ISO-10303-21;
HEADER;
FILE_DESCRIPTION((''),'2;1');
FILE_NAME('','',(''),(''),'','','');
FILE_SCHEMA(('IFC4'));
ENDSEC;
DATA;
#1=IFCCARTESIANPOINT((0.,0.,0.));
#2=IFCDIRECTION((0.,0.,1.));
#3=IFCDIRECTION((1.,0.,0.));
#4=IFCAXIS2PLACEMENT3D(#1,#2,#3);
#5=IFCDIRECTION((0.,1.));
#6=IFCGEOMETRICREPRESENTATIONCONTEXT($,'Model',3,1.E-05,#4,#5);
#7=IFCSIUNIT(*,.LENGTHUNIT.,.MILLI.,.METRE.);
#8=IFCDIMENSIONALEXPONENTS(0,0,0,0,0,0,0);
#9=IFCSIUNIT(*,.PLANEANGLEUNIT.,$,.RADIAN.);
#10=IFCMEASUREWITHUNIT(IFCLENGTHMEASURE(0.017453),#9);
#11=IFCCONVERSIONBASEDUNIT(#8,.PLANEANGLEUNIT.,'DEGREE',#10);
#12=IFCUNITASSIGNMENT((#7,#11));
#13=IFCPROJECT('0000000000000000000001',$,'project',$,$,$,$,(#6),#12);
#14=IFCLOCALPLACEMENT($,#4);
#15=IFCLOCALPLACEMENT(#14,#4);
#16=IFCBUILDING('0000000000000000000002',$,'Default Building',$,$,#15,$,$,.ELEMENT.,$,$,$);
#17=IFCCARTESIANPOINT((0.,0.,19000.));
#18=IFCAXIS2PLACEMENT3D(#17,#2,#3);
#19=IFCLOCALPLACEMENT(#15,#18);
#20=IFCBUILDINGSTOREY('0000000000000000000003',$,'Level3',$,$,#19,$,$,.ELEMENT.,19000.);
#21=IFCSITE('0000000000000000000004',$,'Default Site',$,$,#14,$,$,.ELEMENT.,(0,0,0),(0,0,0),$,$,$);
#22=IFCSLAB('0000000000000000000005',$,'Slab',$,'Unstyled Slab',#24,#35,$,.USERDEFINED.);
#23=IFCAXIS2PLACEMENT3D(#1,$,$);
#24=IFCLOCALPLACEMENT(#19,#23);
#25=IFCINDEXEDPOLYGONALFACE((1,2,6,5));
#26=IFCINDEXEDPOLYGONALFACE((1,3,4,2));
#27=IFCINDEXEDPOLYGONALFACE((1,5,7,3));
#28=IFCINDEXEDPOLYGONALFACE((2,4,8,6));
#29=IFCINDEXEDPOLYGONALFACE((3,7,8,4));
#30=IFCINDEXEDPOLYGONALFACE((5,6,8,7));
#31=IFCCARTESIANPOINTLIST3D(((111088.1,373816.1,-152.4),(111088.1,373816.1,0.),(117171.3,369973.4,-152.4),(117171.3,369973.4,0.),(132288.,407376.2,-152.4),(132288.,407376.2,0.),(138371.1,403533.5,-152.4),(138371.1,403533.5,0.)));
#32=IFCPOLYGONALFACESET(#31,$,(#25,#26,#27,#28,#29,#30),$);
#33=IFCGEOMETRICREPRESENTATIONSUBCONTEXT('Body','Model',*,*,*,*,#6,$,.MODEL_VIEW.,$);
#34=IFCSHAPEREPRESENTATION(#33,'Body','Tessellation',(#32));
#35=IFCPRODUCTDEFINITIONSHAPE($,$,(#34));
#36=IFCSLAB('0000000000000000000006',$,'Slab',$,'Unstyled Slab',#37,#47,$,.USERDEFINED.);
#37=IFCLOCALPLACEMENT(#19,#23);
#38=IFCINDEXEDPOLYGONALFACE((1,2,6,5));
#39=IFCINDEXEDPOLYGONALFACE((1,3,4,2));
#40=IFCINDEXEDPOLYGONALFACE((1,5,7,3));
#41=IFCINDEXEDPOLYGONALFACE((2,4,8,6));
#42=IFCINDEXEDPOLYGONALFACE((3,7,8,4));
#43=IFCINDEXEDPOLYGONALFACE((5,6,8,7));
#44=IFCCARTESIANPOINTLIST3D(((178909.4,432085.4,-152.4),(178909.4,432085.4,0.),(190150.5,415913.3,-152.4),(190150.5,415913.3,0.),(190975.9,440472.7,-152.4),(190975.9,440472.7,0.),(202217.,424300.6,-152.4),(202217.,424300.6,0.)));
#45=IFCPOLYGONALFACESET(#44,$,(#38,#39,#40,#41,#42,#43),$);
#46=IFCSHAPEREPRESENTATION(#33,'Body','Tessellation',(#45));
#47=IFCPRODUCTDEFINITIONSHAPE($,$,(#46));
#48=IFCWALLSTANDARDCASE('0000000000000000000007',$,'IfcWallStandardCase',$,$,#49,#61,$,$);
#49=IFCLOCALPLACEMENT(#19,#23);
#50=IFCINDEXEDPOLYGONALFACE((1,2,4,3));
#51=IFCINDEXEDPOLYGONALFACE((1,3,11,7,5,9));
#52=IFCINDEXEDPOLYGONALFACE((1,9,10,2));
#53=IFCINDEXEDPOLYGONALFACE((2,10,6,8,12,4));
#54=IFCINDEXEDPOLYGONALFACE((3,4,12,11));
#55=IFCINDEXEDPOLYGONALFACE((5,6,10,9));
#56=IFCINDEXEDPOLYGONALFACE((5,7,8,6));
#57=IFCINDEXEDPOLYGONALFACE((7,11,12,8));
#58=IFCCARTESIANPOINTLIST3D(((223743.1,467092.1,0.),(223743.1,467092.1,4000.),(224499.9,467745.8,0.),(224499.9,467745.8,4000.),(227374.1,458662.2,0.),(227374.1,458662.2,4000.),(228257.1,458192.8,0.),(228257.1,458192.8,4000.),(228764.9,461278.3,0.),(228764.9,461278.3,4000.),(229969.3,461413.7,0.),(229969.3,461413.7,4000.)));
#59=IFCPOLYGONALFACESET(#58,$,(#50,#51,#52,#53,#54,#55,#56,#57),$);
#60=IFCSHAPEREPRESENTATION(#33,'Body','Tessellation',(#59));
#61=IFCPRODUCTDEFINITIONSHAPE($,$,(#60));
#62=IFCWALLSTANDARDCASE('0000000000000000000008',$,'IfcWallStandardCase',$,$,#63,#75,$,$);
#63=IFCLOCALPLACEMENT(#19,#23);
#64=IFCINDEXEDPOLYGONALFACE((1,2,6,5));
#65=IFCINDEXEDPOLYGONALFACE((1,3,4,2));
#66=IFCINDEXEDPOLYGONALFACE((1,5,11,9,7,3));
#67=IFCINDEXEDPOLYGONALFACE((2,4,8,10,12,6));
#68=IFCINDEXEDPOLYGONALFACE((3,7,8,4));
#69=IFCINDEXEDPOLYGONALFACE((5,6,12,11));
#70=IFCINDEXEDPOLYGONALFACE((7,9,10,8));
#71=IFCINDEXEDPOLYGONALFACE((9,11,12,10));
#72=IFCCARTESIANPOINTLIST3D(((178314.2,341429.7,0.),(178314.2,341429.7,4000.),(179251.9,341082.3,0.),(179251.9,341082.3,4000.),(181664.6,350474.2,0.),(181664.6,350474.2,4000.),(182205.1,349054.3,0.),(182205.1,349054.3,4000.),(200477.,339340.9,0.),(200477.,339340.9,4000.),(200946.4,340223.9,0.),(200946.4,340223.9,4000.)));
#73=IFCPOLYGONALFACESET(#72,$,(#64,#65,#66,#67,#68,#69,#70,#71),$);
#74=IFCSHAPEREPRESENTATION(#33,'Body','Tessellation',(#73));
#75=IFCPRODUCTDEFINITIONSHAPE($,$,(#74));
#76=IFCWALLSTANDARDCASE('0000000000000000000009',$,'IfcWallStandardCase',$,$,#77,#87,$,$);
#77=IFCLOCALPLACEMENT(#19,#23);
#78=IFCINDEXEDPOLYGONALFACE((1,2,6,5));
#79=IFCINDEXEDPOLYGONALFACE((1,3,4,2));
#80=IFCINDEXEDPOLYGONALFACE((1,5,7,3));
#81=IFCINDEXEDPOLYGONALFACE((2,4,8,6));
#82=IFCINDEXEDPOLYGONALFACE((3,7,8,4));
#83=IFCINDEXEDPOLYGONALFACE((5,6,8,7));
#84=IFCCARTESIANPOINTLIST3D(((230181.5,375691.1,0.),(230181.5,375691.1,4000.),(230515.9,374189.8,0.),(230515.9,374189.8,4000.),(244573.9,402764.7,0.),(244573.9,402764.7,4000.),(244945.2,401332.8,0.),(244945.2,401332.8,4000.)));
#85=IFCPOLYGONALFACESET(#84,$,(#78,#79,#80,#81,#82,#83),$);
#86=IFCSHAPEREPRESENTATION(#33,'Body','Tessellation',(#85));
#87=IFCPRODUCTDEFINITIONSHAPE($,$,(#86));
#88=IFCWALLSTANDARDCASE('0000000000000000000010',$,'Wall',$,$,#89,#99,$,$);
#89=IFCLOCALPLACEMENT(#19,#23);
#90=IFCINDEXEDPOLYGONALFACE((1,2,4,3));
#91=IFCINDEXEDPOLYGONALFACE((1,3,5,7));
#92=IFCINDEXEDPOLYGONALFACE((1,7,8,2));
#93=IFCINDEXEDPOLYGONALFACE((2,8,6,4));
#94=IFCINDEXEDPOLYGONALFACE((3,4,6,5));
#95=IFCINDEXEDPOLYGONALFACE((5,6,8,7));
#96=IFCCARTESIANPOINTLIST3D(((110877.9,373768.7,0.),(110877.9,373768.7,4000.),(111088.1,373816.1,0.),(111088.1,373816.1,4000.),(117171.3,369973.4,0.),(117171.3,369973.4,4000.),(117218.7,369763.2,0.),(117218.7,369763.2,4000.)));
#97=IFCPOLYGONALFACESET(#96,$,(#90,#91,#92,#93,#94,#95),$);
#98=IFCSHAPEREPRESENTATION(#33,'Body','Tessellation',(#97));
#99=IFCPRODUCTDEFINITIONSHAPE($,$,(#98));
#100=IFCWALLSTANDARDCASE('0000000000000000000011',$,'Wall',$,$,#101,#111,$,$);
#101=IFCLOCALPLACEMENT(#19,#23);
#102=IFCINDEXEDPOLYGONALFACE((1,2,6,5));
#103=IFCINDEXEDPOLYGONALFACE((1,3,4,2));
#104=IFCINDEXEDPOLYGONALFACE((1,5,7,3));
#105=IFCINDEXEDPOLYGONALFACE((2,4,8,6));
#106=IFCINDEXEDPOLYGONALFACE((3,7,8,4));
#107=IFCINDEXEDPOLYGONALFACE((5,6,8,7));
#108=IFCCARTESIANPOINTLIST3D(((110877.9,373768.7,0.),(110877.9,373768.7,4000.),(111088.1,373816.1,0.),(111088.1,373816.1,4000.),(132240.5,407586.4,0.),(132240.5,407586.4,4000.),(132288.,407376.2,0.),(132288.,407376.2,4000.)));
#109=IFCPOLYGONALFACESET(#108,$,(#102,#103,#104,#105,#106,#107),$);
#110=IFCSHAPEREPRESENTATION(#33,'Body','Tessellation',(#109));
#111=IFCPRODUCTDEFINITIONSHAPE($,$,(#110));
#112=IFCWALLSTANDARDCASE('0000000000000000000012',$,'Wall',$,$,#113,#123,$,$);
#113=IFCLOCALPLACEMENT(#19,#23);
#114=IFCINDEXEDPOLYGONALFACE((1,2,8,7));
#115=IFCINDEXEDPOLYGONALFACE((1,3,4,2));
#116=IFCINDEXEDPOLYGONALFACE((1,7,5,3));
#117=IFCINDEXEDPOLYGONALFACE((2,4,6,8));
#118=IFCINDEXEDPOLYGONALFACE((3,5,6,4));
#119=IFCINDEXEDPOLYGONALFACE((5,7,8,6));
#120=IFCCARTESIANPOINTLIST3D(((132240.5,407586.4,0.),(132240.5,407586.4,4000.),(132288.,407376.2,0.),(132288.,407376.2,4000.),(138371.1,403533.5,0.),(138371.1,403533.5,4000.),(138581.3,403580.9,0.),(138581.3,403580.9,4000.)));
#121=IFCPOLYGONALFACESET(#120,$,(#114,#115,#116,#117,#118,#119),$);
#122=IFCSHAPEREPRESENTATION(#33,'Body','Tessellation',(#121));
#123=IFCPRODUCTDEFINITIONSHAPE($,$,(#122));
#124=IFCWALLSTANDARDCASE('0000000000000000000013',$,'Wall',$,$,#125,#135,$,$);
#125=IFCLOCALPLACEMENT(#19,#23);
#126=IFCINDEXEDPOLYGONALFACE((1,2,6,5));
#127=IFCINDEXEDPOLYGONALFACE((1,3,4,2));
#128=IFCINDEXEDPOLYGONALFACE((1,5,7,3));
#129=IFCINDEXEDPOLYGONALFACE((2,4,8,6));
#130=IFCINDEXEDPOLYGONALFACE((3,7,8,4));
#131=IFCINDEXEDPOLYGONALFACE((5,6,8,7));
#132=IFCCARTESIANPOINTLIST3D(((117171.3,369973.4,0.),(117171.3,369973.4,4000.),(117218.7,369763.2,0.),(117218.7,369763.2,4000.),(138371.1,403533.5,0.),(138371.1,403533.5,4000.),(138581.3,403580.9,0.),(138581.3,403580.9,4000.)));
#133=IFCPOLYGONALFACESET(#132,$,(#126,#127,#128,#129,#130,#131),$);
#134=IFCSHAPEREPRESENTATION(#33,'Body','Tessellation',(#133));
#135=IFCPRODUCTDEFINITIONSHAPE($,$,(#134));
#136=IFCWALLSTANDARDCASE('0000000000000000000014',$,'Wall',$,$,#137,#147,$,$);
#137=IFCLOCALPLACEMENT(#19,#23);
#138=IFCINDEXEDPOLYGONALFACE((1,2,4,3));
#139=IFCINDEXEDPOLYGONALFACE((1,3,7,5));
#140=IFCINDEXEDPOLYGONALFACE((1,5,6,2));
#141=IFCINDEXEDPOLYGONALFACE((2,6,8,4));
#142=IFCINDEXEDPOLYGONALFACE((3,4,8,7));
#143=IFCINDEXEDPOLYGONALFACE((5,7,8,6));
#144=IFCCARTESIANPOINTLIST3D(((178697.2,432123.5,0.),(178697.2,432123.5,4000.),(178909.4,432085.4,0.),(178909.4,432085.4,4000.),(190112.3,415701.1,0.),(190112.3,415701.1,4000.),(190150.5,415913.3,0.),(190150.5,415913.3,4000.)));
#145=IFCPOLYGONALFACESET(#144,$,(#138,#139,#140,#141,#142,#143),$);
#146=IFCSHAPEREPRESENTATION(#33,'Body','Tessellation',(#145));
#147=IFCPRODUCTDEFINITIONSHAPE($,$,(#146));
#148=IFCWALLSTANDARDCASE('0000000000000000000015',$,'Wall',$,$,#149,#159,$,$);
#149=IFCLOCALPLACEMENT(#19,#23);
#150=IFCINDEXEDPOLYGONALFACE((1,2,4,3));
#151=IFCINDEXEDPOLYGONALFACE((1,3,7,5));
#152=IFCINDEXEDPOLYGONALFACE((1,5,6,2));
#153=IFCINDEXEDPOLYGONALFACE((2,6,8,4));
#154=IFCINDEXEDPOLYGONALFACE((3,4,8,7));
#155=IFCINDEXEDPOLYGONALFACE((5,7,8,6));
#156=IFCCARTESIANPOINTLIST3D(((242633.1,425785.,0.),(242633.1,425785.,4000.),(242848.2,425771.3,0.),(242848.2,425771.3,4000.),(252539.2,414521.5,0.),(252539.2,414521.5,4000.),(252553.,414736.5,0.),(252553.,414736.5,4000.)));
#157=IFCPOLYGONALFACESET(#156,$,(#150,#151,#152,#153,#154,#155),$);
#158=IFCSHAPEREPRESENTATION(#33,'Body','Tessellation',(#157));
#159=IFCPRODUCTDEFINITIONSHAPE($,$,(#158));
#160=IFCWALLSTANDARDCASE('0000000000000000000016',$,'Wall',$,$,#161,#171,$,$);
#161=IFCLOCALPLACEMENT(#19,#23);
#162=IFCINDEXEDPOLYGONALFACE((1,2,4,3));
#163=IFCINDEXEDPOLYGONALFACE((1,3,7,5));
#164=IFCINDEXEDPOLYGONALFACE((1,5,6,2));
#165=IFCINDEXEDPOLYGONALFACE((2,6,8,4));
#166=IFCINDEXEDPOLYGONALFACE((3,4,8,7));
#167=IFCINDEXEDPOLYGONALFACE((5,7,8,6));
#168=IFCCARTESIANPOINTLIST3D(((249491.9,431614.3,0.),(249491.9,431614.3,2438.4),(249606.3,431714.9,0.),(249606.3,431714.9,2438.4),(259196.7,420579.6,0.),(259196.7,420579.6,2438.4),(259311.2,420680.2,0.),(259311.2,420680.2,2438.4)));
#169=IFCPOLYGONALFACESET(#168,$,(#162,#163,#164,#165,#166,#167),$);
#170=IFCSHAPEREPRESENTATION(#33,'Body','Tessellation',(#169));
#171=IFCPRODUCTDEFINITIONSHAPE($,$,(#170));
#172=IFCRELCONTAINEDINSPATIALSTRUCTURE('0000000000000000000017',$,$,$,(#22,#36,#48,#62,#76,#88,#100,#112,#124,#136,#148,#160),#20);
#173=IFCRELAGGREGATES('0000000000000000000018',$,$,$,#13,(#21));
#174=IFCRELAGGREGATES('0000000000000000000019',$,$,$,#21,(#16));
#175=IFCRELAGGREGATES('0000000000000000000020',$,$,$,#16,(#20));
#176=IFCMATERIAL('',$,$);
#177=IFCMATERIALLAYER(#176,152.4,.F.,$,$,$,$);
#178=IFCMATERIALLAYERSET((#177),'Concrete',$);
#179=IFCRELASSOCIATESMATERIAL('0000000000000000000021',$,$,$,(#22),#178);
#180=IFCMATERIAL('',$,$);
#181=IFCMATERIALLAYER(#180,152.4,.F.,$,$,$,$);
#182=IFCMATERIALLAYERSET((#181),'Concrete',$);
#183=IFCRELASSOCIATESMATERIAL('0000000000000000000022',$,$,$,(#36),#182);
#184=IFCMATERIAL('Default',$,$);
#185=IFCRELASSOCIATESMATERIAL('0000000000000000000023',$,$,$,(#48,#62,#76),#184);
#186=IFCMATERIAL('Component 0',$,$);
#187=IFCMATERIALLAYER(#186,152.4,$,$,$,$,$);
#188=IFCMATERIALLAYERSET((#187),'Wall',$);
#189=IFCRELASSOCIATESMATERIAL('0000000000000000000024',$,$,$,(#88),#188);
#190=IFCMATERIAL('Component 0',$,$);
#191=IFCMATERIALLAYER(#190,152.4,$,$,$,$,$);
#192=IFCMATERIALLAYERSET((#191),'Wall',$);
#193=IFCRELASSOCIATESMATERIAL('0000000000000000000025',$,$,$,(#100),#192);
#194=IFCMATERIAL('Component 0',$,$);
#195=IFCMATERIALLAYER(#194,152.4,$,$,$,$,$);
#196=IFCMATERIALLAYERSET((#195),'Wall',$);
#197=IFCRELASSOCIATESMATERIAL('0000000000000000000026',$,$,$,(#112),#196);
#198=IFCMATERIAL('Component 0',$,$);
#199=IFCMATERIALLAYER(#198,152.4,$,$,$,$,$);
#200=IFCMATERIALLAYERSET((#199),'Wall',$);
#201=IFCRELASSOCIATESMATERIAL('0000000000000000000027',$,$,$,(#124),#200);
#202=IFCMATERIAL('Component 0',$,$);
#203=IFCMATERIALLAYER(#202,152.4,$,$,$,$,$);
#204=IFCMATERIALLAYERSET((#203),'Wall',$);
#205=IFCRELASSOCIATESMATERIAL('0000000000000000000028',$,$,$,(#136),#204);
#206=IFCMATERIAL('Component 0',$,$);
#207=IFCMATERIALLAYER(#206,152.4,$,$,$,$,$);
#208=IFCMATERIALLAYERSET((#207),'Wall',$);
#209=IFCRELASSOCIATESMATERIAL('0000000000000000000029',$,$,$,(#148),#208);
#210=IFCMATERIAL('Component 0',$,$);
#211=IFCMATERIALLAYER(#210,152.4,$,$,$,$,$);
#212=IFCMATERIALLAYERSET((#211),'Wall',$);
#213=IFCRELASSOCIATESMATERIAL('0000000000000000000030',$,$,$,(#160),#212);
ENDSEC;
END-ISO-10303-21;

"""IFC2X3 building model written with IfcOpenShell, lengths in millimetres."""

from ifc_helpers import new_model, entity, si_unit, converted_unit, direction, frame, origin_with_axes, place, context, subcontext, project, spatial, polyline, outline, extrude, material, layer, layer_set, layer_usage, element, save


model = new_model("IFC2X3")

# Units and contexts
model_context = context("Model", 3, precision=1e-05, world=origin_with_axes(), true_north=direction((0.0, 1.0)))
body_context = subcontext(model_context, "Body", "Model", "MODEL_VIEW")
ifc_project = project(units=[si_unit("LENGTHUNIT", "METRE", prefix="MILLI"), converted_unit("PLANEANGLEUNIT", "DEGREE", entity("IfcLengthMeasure", 0.017453), si_unit("PLANEANGLEUNIT", "RADIAN"), dimensions=[0, 0, 0, 0, 0, 0, 0])], contexts=[model_context])

# Site, building, storey
site_placement = place(None, origin_with_axes())
site = spatial("IfcSite", under=ifc_project, at=site_placement, Name="Default Site", CompositionType="ELEMENT", RefLatitude=(0, 0, 0), RefLongitude=(0, 0, 0))
building_placement = place(site_placement, origin_with_axes())
building = spatial("IfcBuilding", under=site, at=building_placement, Name="Default Building", CompositionType="ELEMENT")
storey_placement = place(building_placement, frame((0.0, 0.0, 19000.0), z_axis=(0.0, 0.0, 1.0), x_axis=(1.0, 0.0, 0.0)))
storey = spatial("IfcBuildingStorey", under=building, at=storey_placement, Name="Level3", CompositionType="ELEMENT", Elevation=19000.0)

# Slabs
ifc_material_1 = material(Name="")
ifc_layer_1 = layer(ifc_material_1, 152.4, ventilated=False)
ifc_layer_set_1 = layer_set([ifc_layer_1], Name="Concrete")
ifc_layer_usage_1 = layer_usage(ifc_layer_set_1, "AXIS3", "NEGATIVE", 0.0)
slab_1_placement = place(storey_placement, frame((0.0, 0.0, -19000.0), z_axis=(0.0, 0.0, 1.0), x_axis=(1.0, 0.0, 0.0)))
element("IfcSlab", 1, at=slab_1_placement, inside=storey, material=ifc_layer_usage_1, Name="Slab", ObjectType="Unstyled Slab", PredefinedType="USERDEFINED", context=body_context, shape_type="SweptSolid", body=[
    extrude(outline(polyline([(0.0, 39695.2), (7195.2, 39695.2), (7195.2, 0.0), (0.0, 0.0), (0.0, 39695.2)])), frame((117171.3, 369973.4, 18847.6), z_axis=(0.0, 0.0, -1.0), x_axis=(-0.845443, 0.534065, 0.0)), (0.0, 0.0, -1.0), 152.4),
])
ifc_material_2 = material(Name="")
ifc_layer_2 = layer(ifc_material_2, 152.4, ventilated=False)
ifc_layer_set_2 = layer_set([ifc_layer_2], Name="Concrete")
ifc_layer_usage_2 = layer_usage(ifc_layer_set_2, "AXIS3", "NEGATIVE", 0.0)
slab_2_placement = place(storey_placement, frame((0.0, 0.0, -19000.0), z_axis=(0.0, 0.0, 1.0), x_axis=(1.0, 0.0, 0.0)))
element("IfcSlab", 2, at=slab_2_placement, inside=storey, material=ifc_layer_usage_2, Name="Slab", ObjectType="Unstyled Slab", PredefinedType="USERDEFINED", context=body_context, shape_type="SweptSolid", body=[
    extrude(outline(polyline([(0.0, 19695.2), (14695.2, 19695.2), (14695.2, 0.0), (0.0, 0.0), (0.0, 19695.2)])), frame((178909.4, 432085.4, 18847.6), z_axis=(0.0, 0.0, -1.0), x_axis=(0.82112, 0.570755, 0.0)), (0.0, 0.0, -1.0), 152.4),
])

# Walls
ifc_material_3 = material(Name="Default")
wall_1_placement = place(storey_placement, frame((0.0, 0.0, -19000.0), z_axis=(0.0, 0.0, 1.0), x_axis=(1.0, 0.0, 0.0)))
element("IfcWallStandardCase", 3, at=wall_1_placement, inside=storey, material=ifc_material_3, Name="IfcWallStandardCase", context=body_context, shape_type="SweptSolid", body=[
    extrude(outline(polyline([(227374.1, 458662.2), (228764.9, 461278.3), (223743.1, 467092.1), (224499.9, 467745.8), (229969.3, 461413.7), (228257.1, 458192.8), (227374.1, 458662.2)])), frame((0.0, 0.0, 19000.0), z_axis=(0.0, 0.0, 1.0), x_axis=(1.0, 0.0, 0.0)), (0.0, 0.0, 1.0), 4000.0),
])
wall_2_placement = place(storey_placement, frame((0.0, 0.0, -19000.0), z_axis=(0.0, 0.0, 1.0), x_axis=(1.0, 0.0, 0.0)))
element("IfcWallStandardCase", 4, at=wall_2_placement, inside=storey, material=ifc_material_3, Name="IfcWallStandardCase", context=body_context, shape_type="SweptSolid", body=[
    extrude(outline(polyline([(178314.2, 341429.7), (181664.6, 350474.2), (200946.4, 340223.9), (200477.0, 339340.9), (182205.1, 349054.3), (179251.9, 341082.3), (178314.2, 341429.7)])), frame((0.0, 0.0, 19000.0), z_axis=(0.0, 0.0, 1.0), x_axis=(1.0, 0.0, 0.0)), (0.0, 0.0, 1.0), 4000.0),
])
wall_3_placement = place(storey_placement, frame((0.0, 0.0, -19000.0), z_axis=(0.0, 0.0, 1.0), x_axis=(1.0, 0.0, 0.0)))
element("IfcWallStandardCase", 5, at=wall_3_placement, inside=storey, material=ifc_material_3, Name="IfcWallStandardCase", context=body_context, shape_type="SweptSolid", body=[
    extrude(outline(polyline([(244945.2, 401332.8), (244573.9, 402764.7), (230181.5, 375691.1), (230515.9, 374189.8), (244945.2, 401332.8)])), frame((0.0, 0.0, 19000.0), z_axis=(0.0, 0.0, 1.0), x_axis=(1.0, 0.0, 0.0)), (0.0, 0.0, 1.0), 4000.0),
])
ifc_material_4 = material(Name="Component 0")
ifc_layer_3 = layer(ifc_material_4, 152.4)
ifc_layer_set_3 = layer_set([ifc_layer_3], Name="Wall")
ifc_layer_usage_3 = layer_usage(ifc_layer_set_3, "AXIS2", "POSITIVE", -76.2)
wall_4_placement = place(storey_placement, frame((117195.0, 369868.3, 0.0), z_axis=(0.0, 0.0, 1.0), x_axis=(-0.845443, 0.534065, 0.0)))
element("IfcWallStandardCase", 6, at=wall_4_placement, inside=storey, material=ifc_layer_usage_3, Name="Wall", context=body_context, shape_type="SweptSolid", body=[
    extrude(outline(polyline([(76.2, -76.2), (-76.2, 76.2), (7423.8, 76.2), (7271.4, -76.2), (76.2, -76.2)])), origin_with_axes(), (0.0, 0.0, 1.0), 4000.0),
])
ifc_material_5 = material(Name="Component 0")
ifc_layer_4 = layer(ifc_material_5, 152.4)
ifc_layer_set_4 = layer_set([ifc_layer_4], Name="Wall")
ifc_layer_usage_4 = layer_usage(ifc_layer_set_4, "AXIS2", "POSITIVE", -76.2)
wall_5_placement = place(storey_placement, frame((110983.0, 373792.4, 0.0), z_axis=(0.0, 0.0, 1.0), x_axis=(0.534065, 0.845443, 0.0)))
element("IfcWallStandardCase", 7, at=wall_5_placement, inside=storey, material=ifc_layer_usage_4, Name="Wall", context=body_context, shape_type="SweptSolid", body=[
    extrude(outline(polyline([(76.2, -76.2), (-76.2, 76.2), (39923.8, 76.2), (39771.4, -76.2), (76.2, -76.2)])), origin_with_axes(), (0.0, 0.0, 1.0), 4000.0),
])
ifc_material_6 = material(Name="Component 0")
ifc_layer_5 = layer(ifc_material_6, 152.4)
ifc_layer_set_5 = layer_set([ifc_layer_5], Name="Wall")
ifc_layer_usage_5 = layer_usage(ifc_layer_set_5, "AXIS2", "POSITIVE", -76.2)
wall_6_placement = place(storey_placement, frame((132264.2, 407481.3, 0.0), z_axis=(0.0, 0.0, 1.0), x_axis=(0.845443, -0.534065, 0.0)))
element("IfcWallStandardCase", 8, at=wall_6_placement, inside=storey, material=ifc_layer_usage_5, Name="Wall", context=body_context, shape_type="SweptSolid", body=[
    extrude(outline(polyline([(76.2, -76.2), (-76.2, 76.2), (7423.8, 76.2), (7271.4, -76.2), (76.2, -76.2)])), origin_with_axes(), (0.0, 0.0, 1.0), 4000.0),
])
ifc_material_7 = material(Name="Component 0")
ifc_layer_6 = layer(ifc_material_7, 152.4)
ifc_layer_set_6 = layer_set([ifc_layer_6], Name="Wall")
ifc_layer_usage_6 = layer_usage(ifc_layer_set_6, "AXIS2", "POSITIVE", -76.2)
wall_7_placement = place(storey_placement, frame((138476.2, 403557.2, 0.0), z_axis=(0.0, 0.0, 1.0), x_axis=(-0.534065, -0.845443, 0.0)))
element("IfcWallStandardCase", 9, at=wall_7_placement, inside=storey, material=ifc_layer_usage_6, Name="Wall", context=body_context, shape_type="SweptSolid", body=[
    extrude(outline(polyline([(76.2, -76.2), (-76.2, 76.2), (39923.8, 76.2), (39771.4, -76.2), (76.2, -76.2)])), origin_with_axes(), (0.0, 0.0, 1.0), 4000.0),
])
ifc_material_8 = material(Name="Component 0")
ifc_layer_7 = layer(ifc_material_8, 152.4)
ifc_layer_set_7 = layer_set([ifc_layer_7], Name="Wall")
ifc_layer_usage_7 = layer_usage(ifc_layer_set_7, "AXIS2", "POSITIVE", -76.2)
wall_8_placement = place(storey_placement, frame((190131.4, 415807.2, 0.0), z_axis=(0.0, 0.0, 1.0), x_axis=(-0.570755, 0.82112, 0.0)))
element("IfcWallStandardCase", 10, at=wall_8_placement, inside=storey, material=ifc_layer_usage_7, Name="Wall", context=body_context, shape_type="SweptSolid", body=[
    extrude(outline(polyline([(76.2, -76.2), (-76.2, 76.2), (19923.8, 76.2), (19771.4, -76.2), (76.2, -76.2)])), origin_with_axes(), (0.0, 0.0, 1.0), 4000.0),
])
ifc_material_9 = material(Name="Component 0")
ifc_layer_8 = layer(ifc_material_9, 152.4)
ifc_layer_set_8 = layer_set([ifc_layer_8], Name="Wall")
ifc_layer_usage_8 = layer_usage(ifc_layer_set_8, "AXIS2", "POSITIVE", -76.2)
wall_9_placement = place(storey_placement, frame((252546.1, 414629.0, 0.0), z_axis=(0.0, 0.0, 1.0), x_axis=(-0.660409, 0.750906, 0.0)))
element("IfcWallStandardCase", 11, at=wall_9_placement, inside=storey, material=ifc_layer_usage_8, Name="Wall", context=body_context, shape_type="SweptSolid", body=[
    extrude(outline(polyline([(76.2, -76.2), (-76.2, 76.2), (14923.8, 76.2), (14771.4, -76.2), (76.2, -76.2)])), origin_with_axes(), (0.0, 0.0, 1.0), 4000.0),
])
ifc_material_10 = material(Name="Component 0")
ifc_layer_9 = layer(ifc_material_10, 152.4)
ifc_layer_set_9 = layer_set([ifc_layer_9], Name="Wall")
ifc_layer_usage_9 = layer_usage(ifc_layer_set_9, "AXIS2", "POSITIVE", -76.2)
wall_10_placement = place(storey_placement, frame((259304.3, 420572.7, 0.0), z_axis=(0.0, 0.0, 1.0), x_axis=(-0.660409, 0.750906, 0.0)))
element("IfcWallStandardCase", 12, at=wall_10_placement, inside=storey, material=ifc_layer_usage_9, Name="Wall", context=body_context, shape_type="SweptSolid", body=[
    extrude(outline(polyline([(76.2, -76.2), (76.2, 76.2), (14771.4, 76.2), (14771.4, -76.2), (76.2, -76.2)])), origin_with_axes(), (0.0, 0.0, 1.0), 2438.4),
])

save(model, "model.ifc")
